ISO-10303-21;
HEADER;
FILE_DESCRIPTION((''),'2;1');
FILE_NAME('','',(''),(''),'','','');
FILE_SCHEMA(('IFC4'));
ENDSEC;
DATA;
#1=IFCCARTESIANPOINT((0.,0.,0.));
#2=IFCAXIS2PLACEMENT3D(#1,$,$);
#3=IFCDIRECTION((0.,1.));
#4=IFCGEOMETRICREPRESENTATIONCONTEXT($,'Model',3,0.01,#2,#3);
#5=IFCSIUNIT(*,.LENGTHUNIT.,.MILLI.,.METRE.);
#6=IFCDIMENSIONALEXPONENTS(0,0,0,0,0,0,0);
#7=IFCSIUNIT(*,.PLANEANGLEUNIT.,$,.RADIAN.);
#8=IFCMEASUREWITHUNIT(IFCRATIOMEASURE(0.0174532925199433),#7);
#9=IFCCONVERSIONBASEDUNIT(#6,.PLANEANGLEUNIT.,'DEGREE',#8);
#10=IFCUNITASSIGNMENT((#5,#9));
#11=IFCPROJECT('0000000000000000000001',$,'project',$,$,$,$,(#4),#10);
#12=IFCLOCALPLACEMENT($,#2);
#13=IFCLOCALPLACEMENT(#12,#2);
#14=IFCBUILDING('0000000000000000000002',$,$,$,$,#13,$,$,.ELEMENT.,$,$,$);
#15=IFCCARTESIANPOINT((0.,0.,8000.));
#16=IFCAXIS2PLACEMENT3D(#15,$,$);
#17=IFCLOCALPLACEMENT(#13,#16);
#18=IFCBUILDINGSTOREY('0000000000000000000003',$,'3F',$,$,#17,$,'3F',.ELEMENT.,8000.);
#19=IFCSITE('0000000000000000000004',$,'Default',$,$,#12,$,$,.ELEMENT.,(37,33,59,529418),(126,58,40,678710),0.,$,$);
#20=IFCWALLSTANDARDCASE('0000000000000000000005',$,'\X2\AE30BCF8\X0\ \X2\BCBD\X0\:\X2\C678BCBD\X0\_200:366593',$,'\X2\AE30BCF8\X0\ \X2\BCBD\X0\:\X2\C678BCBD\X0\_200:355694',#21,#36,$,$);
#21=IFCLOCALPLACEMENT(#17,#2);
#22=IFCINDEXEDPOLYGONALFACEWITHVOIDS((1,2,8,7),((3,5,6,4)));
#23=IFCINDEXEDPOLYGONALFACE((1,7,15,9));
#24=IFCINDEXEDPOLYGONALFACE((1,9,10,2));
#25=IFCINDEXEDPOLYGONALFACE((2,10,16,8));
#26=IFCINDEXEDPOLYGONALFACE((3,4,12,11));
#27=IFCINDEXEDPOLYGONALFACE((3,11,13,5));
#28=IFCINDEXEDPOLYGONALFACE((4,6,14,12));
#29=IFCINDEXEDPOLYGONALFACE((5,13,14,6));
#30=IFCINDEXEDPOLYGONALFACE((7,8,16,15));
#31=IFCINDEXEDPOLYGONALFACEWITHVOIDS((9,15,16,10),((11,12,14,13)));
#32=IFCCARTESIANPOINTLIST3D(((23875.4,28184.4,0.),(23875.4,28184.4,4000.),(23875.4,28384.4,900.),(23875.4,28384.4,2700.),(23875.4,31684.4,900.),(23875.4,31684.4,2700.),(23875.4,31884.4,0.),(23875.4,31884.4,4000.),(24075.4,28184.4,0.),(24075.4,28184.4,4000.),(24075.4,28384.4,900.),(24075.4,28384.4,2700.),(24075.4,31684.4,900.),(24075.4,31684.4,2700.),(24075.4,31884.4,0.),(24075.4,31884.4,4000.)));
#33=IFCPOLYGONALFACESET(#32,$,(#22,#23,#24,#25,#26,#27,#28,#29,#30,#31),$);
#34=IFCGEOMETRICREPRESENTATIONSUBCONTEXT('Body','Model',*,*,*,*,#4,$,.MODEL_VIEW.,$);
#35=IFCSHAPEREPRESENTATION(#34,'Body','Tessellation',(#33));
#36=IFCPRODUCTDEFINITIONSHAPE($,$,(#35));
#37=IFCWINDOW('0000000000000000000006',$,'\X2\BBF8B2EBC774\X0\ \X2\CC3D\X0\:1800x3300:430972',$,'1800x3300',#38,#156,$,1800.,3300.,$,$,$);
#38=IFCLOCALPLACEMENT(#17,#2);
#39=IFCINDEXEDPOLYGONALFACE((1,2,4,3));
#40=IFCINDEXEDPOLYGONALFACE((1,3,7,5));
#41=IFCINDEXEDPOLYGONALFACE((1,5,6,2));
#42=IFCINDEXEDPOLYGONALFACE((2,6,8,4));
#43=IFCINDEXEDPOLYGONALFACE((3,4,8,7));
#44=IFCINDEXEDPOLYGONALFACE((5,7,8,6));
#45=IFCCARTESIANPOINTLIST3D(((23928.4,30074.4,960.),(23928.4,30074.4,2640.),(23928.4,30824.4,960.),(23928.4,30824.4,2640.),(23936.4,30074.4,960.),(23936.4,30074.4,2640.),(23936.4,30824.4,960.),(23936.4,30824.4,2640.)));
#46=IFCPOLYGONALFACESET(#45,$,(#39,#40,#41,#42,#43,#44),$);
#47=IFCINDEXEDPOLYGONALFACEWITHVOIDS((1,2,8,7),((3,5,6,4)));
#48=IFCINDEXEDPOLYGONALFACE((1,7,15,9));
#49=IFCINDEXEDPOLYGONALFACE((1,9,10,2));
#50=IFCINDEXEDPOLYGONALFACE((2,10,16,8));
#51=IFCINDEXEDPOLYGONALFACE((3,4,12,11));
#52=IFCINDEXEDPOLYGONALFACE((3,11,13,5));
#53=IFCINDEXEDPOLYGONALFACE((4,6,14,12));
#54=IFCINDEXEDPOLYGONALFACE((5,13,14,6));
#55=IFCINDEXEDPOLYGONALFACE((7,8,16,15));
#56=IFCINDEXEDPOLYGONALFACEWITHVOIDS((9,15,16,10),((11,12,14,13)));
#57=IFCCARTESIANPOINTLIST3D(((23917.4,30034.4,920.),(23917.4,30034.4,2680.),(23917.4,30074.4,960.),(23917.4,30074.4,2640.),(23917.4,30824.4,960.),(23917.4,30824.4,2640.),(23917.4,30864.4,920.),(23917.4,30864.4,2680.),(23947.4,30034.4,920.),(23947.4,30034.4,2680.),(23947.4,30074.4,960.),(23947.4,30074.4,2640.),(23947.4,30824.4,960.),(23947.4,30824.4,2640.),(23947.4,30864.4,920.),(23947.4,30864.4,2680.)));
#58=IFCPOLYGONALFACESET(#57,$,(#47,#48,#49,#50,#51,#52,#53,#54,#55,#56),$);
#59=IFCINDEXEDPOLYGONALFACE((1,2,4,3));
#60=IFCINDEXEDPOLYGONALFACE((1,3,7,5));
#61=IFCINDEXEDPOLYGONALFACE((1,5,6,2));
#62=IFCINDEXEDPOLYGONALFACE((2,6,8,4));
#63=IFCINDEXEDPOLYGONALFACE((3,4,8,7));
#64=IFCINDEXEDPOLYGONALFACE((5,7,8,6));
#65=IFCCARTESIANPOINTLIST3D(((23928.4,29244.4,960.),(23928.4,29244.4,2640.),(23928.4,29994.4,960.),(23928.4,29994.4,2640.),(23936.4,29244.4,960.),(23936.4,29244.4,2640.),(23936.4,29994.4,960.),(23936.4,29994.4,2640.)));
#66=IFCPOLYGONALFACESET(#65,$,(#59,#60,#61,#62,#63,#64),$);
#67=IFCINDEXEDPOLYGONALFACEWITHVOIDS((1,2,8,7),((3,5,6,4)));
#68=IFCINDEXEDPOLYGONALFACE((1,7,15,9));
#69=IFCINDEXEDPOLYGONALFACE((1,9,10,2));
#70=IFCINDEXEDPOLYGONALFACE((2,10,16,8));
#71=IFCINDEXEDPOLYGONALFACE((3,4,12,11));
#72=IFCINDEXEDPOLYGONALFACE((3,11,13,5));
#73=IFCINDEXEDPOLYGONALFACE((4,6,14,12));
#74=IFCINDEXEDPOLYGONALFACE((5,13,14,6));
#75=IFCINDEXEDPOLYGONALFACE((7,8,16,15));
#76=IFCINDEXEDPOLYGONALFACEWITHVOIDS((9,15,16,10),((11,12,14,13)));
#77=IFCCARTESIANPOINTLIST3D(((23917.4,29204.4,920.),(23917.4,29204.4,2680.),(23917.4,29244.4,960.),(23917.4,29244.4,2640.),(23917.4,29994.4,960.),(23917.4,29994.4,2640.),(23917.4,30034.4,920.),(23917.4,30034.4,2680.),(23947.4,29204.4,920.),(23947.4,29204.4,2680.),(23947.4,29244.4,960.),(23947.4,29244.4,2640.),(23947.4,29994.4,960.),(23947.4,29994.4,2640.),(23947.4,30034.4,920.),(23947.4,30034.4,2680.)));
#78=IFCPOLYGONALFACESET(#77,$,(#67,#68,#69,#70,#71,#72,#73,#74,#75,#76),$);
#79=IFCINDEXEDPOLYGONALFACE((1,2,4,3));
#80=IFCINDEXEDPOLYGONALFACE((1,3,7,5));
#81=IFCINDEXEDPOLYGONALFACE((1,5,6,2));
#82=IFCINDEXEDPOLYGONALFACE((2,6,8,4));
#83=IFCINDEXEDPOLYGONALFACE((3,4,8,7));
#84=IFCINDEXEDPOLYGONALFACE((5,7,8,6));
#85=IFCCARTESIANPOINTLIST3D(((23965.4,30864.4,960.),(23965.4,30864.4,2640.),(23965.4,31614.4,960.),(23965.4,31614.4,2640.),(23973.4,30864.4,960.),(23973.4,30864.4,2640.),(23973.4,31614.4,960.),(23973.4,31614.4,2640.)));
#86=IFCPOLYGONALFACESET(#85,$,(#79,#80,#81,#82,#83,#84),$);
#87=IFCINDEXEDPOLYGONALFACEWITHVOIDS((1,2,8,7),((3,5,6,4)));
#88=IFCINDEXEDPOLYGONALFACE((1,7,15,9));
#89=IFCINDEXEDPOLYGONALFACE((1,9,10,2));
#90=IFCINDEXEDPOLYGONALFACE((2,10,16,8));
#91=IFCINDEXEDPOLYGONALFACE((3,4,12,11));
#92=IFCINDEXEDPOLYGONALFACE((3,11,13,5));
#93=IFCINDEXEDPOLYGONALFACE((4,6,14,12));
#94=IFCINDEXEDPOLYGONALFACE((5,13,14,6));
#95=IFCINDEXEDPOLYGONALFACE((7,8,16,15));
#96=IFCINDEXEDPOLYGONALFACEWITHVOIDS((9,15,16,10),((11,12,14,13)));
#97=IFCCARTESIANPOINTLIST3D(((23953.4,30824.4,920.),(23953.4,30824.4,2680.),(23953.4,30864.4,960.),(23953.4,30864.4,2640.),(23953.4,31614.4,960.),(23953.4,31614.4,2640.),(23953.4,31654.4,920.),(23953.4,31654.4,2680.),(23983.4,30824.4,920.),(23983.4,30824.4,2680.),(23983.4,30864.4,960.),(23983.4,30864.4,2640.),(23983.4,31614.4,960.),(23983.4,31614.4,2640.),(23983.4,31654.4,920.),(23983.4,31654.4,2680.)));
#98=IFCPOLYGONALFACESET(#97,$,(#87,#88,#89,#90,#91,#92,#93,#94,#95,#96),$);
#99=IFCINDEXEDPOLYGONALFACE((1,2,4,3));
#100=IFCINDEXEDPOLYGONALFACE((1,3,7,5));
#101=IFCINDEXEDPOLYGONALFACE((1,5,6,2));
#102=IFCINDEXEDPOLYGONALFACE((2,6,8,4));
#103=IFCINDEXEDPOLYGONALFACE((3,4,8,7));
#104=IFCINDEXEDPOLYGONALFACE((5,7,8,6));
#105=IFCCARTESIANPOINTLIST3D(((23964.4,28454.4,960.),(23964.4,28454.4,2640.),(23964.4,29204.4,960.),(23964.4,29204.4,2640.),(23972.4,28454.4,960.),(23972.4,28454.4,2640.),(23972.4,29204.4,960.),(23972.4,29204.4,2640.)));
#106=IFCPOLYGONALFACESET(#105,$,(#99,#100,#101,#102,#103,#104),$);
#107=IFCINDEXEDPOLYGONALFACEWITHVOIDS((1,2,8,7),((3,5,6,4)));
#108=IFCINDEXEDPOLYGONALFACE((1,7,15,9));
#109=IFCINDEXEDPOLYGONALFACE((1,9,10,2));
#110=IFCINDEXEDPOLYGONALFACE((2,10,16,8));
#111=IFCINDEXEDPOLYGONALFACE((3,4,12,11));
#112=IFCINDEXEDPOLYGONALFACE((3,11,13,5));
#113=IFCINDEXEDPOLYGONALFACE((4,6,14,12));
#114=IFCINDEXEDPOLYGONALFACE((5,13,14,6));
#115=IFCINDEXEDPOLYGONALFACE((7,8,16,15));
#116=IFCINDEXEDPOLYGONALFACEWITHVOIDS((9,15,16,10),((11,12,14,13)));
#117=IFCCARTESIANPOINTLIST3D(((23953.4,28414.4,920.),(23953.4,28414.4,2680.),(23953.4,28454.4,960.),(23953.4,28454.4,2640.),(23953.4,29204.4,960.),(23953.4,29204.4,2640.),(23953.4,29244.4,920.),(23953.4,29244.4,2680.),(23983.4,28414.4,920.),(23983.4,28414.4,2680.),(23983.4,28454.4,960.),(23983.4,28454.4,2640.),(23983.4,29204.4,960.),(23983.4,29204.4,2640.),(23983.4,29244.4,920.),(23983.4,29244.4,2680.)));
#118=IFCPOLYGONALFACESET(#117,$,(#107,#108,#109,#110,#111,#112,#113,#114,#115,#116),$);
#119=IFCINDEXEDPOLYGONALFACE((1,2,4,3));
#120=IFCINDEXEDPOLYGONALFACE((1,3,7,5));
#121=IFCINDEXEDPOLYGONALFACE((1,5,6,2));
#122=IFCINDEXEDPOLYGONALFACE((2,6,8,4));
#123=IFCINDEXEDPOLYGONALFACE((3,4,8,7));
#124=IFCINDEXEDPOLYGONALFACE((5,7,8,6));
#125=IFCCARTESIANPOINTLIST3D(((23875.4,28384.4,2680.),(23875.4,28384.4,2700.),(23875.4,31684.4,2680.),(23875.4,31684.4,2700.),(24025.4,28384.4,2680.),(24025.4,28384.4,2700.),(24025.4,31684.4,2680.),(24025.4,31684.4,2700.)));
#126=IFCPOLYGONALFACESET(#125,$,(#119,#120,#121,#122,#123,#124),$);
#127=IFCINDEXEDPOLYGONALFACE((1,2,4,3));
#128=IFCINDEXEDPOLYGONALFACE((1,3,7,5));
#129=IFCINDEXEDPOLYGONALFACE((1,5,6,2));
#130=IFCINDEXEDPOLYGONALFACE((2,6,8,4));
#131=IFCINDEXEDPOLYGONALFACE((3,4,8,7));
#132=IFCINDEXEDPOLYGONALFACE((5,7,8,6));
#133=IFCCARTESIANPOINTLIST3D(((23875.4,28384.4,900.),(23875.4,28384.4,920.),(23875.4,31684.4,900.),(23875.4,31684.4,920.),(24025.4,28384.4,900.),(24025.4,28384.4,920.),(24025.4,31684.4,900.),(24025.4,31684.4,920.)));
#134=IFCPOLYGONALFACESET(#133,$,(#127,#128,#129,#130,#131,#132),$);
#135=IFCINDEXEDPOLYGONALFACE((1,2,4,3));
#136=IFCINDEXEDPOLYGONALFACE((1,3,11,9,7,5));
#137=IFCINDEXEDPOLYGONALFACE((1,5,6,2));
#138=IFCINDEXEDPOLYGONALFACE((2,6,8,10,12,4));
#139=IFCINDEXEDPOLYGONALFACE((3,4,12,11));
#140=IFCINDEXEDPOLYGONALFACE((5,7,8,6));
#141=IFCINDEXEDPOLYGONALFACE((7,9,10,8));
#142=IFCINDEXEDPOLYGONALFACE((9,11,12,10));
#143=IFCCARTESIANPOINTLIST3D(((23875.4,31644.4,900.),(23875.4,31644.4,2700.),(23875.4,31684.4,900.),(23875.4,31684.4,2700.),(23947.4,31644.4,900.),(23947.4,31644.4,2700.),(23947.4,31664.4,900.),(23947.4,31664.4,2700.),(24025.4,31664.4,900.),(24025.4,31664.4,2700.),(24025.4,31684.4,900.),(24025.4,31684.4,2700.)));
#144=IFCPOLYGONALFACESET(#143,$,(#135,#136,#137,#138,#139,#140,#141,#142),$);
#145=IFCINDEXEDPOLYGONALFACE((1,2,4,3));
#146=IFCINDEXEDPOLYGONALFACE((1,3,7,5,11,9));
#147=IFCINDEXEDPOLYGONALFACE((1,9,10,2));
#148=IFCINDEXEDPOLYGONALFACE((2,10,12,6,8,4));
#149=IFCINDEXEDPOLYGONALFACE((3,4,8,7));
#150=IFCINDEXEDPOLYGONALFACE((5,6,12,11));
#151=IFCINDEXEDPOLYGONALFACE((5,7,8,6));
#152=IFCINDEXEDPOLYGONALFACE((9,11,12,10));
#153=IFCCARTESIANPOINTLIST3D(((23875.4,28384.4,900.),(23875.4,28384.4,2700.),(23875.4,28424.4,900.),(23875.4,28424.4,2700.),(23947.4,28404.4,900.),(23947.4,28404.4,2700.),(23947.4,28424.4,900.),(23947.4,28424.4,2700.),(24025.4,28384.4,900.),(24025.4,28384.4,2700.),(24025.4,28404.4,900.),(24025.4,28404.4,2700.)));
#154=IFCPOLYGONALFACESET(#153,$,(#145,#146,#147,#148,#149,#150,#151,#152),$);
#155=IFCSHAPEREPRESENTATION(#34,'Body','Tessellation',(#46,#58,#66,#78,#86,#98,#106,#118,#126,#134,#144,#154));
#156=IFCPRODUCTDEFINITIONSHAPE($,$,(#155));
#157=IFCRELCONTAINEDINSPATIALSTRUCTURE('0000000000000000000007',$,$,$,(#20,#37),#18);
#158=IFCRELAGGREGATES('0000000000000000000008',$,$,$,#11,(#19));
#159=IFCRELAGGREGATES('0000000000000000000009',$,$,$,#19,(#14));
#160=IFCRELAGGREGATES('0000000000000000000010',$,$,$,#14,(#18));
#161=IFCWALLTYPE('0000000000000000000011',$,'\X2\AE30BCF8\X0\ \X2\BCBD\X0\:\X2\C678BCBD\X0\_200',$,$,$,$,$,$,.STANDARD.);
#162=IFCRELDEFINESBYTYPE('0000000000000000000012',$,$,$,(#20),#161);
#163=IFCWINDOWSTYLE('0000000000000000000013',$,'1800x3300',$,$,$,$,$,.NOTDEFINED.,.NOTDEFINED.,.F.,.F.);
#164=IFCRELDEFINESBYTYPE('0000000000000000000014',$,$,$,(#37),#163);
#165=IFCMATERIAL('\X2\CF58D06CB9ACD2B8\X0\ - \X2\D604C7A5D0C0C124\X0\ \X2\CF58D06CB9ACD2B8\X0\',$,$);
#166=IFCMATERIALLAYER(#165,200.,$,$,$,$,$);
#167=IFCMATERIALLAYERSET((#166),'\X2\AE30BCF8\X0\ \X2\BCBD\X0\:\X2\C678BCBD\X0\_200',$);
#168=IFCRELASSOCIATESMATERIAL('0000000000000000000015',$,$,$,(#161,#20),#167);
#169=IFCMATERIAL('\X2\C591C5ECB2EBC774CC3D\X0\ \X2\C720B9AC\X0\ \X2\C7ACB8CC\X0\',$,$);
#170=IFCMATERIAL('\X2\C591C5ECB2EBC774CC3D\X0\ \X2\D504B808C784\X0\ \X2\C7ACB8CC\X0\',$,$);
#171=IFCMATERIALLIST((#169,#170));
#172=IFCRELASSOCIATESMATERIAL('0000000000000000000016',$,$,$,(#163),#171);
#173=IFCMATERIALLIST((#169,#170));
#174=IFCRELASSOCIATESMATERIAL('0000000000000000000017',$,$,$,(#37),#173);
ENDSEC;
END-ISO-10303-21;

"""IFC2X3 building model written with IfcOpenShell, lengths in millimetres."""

from ifc_helpers import new_model, entity, si_unit, converted_unit, direction, frame, frame_2d, origin, origin_2d_with_axis, place, context, subcontext, project, spatial, polyline, rectangle, outline, extrude, source, transform, mapped, material, material_list, layer, layer_set, layer_usage, type_object, type_shapes, element, fill, save


model = new_model("IFC2X3")

# Units and contexts
model_context = context("Model", 3, precision=0.01, world=origin(), true_north=direction((0.0, 1.0)))
body_context = subcontext(model_context, "Body", "Model", "MODEL_VIEW")
ifc_project = project(units=[si_unit("LENGTHUNIT", "METRE", prefix="MILLI"), converted_unit("PLANEANGLEUNIT", "DEGREE", entity("IfcRatioMeasure", 0.0174532925199433), si_unit("PLANEANGLEUNIT", "RADIAN"), dimensions=[0, 0, 0, 0, 0, 0, 0])], contexts=[model_context])

# Site, building, storey
site_placement = place(None, origin())
site = spatial("IfcSite", under=ifc_project, at=site_placement, Name="Default", CompositionType="ELEMENT", RefLatitude=(37, 33, 59, 529418), RefLongitude=(126, 58, 40, 678710), RefElevation=0.0)
building_placement = place(site_placement, origin())
building = spatial("IfcBuilding", under=site, at=building_placement, CompositionType="ELEMENT")
storey_placement = place(building_placement, frame((0.0, 0.0, 8000.0)))
storey = spatial("IfcBuildingStorey", under=building, at=storey_placement, Name="3F", LongName="3F", CompositionType="ELEMENT", Elevation=8000.0)

# Shared definitions
ifc_material_1 = material(Name="콘크리트 - 현장타설 콘크리트")

# Wall, opening, window
ifc_layer_1 = layer(ifc_material_1, 200.0)
ifc_layer_set_1 = layer_set([ifc_layer_1], Name="기본 벽:외벽_200")
ifc_layer_usage_1 = layer_usage(ifc_layer_set_1, "AXIS2", "NEGATIVE", 100.0)
wall_type_1 = type_object("IfcWallType", Name="기본 벽:외벽_200", PredefinedType="STANDARD", material=ifc_layer_set_1)
wall_1_placement = place(storey_placement, frame((23975.4, 28184.4, 0.0), z_axis=(0.0, 0.0, 1.0), x_axis=(0.0, 1.0, 0.0)))
wall_1 = element("IfcWallStandardCase", 1, at=wall_1_placement, inside=storey, type_object=wall_type_1, material=ifc_layer_usage_1, Name="기본 벽:외벽_200:366593", ObjectType="기본 벽:외벽_200:355694", context=body_context, shape_type="SweptSolid", body=[
    extrude(rectangle(XDim=3700.0, YDim=200.0, at=frame_2d((1850.0, 0.0), x_axis=(-1.0, 0.0))), origin(), (0.0, 0.0, 1.0), 4000.0),
])
opening_1_placement = place(wall_1_placement, frame((200.0, -100.0, 900.0)))
opening_1 = element("IfcOpeningElement", 2, at=opening_1_placement, cuts=wall_1, ObjectType="Opening", context=body_context, shape_type="SweptSolid", body=[
    extrude(rectangle(XDim=1800.0, YDim=3300.0, at=frame_2d((900.0, 1650.0), x_axis=(1.0, 0.0))), frame((0.0, 0.0, 0.0), z_axis=(0.0, 1.0, 0.0), x_axis=(0.0, 0.0, 1.0)), (0.0, 0.0, 1.0), 200.0),
])
ifc_material_2 = material(Name="양여닫이창 유리 재료")
ifc_material_3 = material(Name="양여닫이창 프레임 재료")
ifc_material_list_1 = material_list([ifc_material_2, ifc_material_3])
ifc_material_list_2 = material_list([ifc_material_2, ifc_material_3])
window_style_1 = type_object("IfcWindowStyle", Name="1800x3300", ConstructionType="NOTDEFINED", OperationType="NOTDEFINED", ParameterTakesPrecedence=False, Sizeable=False, material=ifc_material_list_2)
shared_shape_1 = source(origin(), body_context, "Body", "SweptSolid", [
    extrude(rectangle(XDim=8.0, YDim=750.0, at=frame_2d((0.0, 0.0), x_axis=(1.0, 0.0))), frame((2065.0, 143.0, 60.0), z_axis=(0.0, 0.0, 1.0), x_axis=(0.0, 1.0, 0.0)), (0.0, 0.0, 1.0), 1680.0),
    extrude(outline(polyline([(-880.0, -415.0), (880.0, -415.0), (880.0, 415.0), (-880.0, 415.0), (-880.0, -415.0)]), holes=[polyline([(840.0, -375.0), (-840.0, -375.0), (-840.0, 375.0), (840.0, 375.0), (840.0, -375.0)])]), frame((2065.0, 128.0, 900.0), z_axis=(0.0, 1.0, 0.0), x_axis=(0.0, 0.0, -1.0)), (0.0, 0.0, 1.0), 30.0),
    extrude(rectangle(XDim=8.0, YDim=750.0, at=frame_2d((0.0, 0.0), x_axis=(1.0, 0.0))), frame((1235.0, 143.0, 60.0), z_axis=(0.0, 0.0, 1.0), x_axis=(0.0, 1.0, 0.0)), (0.0, 0.0, 1.0), 1680.0),
    extrude(outline(polyline([(-880.0, -415.0), (880.0, -415.0), (880.0, 415.0), (-880.0, 415.0), (-880.0, -415.0)]), holes=[polyline([(840.0, -375.0), (-840.0, -375.0), (-840.0, 375.0), (840.0, 375.0), (840.0, -375.0)])]), frame((1235.0, 128.0, 900.0), z_axis=(0.0, 1.0, 0.0), x_axis=(0.0, 0.0, -1.0)), (0.0, 0.0, 1.0), 30.0),
    extrude(rectangle(XDim=8.0, YDim=750.0, at=frame_2d((0.0, 0.0), x_axis=(1.0, 0.0))), frame((2855.0, 106.0, 60.0), z_axis=(0.0, 0.0, 1.0), x_axis=(0.0, 1.0, 0.0)), (0.0, 0.0, 1.0), 1680.0),
    extrude(outline(polyline([(-880.0, -415.0), (880.0, -415.0), (880.0, 415.0), (-880.0, 415.0), (-880.0, -415.0)]), holes=[polyline([(840.0, -375.0), (-840.0, -375.0), (-840.0, 375.0), (840.0, 375.0), (840.0, -375.0)])]), frame((2855.0, 92.0, 900.0), z_axis=(0.0, 1.0, 0.0), x_axis=(0.0, 0.0, -1.0)), (0.0, 0.0, 1.0), 30.0),
    extrude(rectangle(XDim=8.0, YDim=750.0, at=origin_2d_with_axis()), frame((445.0, 107.0, 60.0), z_axis=(0.0, 0.0, 1.0), x_axis=(0.0, 1.0, 0.0)), (0.0, 0.0, 1.0), 1680.0),
    extrude(outline(polyline([(-880.0, -415.0), (880.0, -415.0), (880.0, 415.0), (-880.0, 415.0), (-880.0, -415.0)]), holes=[polyline([(840.0, -375.0), (-840.0, -375.0), (-840.0, 375.0), (840.0, 375.0), (840.0, -375.0)])]), frame((445.0, 92.0, 900.0), z_axis=(0.0, 1.0, 0.0), x_axis=(0.0, 0.0, -1.0)), (0.0, 0.0, 1.0), 30.0),
    extrude(rectangle(XDim=3300.0, YDim=150.0, at=origin_2d_with_axis()), frame((1650.0, 125.0, 1780.0), z_axis=(0.0, 0.0, 1.0), x_axis=(-1.0, 0.0, 0.0)), (0.0, 0.0, 1.0), 20.0),
    extrude(rectangle(XDim=3300.0, YDim=150.0, at=origin_2d_with_axis()), frame((1650.0, 125.0, 0.0), z_axis=(0.0, 0.0, 1.0), x_axis=(-1.0, 0.0, 0.0)), (0.0, 0.0, 1.0), 20.0),
    extrude(outline(polyline([(-74.0, -20.0), (-2.0, -20.0), (-2.0, 0.0), (76.0, 0.0), (76.0, 20.0), (-74.0, 20.0), (-74.0, -20.0)])), frame((3280.0, 126.0, 0.0), z_axis=(0.0, 0.0, 1.0), x_axis=(0.0, -1.0, 0.0)), (0.0, 0.0, 1.0), 1800.0),
    extrude(outline(polyline([(-20.0, -74.0), (20.0, -74.0), (20.0, 76.0), (0.0, 76.0), (0.0, -2.0), (-20.0, -2.0), (-20.0, -74.0)])), frame((20.0, 126.0, 0.0), z_axis=(0.0, 0.0, 1.0), x_axis=(-1.0, 0.0, 0.0)), (0.0, 0.0, 1.0), 1800.0),
])
type_shapes(window_style_1, [shared_shape_1])
window_1_placement = place(opening_1_placement, origin())
window_1 = element("IfcWindow", 3, at=window_1_placement, inside=storey, type_object=window_style_1, material=ifc_material_list_1, Name="미닫이 창:1800x3300:430972", ObjectType="1800x3300", OverallHeight=1800.0, OverallWidth=3300.0, context=body_context, shape_type="MappedRepresentation", body=[
    mapped(shared_shape_1, transform((0.0, 0.0, 0.0), scale=1.0)),
])
fill(opening_1, window_1)

save(model, "model.ifc")
